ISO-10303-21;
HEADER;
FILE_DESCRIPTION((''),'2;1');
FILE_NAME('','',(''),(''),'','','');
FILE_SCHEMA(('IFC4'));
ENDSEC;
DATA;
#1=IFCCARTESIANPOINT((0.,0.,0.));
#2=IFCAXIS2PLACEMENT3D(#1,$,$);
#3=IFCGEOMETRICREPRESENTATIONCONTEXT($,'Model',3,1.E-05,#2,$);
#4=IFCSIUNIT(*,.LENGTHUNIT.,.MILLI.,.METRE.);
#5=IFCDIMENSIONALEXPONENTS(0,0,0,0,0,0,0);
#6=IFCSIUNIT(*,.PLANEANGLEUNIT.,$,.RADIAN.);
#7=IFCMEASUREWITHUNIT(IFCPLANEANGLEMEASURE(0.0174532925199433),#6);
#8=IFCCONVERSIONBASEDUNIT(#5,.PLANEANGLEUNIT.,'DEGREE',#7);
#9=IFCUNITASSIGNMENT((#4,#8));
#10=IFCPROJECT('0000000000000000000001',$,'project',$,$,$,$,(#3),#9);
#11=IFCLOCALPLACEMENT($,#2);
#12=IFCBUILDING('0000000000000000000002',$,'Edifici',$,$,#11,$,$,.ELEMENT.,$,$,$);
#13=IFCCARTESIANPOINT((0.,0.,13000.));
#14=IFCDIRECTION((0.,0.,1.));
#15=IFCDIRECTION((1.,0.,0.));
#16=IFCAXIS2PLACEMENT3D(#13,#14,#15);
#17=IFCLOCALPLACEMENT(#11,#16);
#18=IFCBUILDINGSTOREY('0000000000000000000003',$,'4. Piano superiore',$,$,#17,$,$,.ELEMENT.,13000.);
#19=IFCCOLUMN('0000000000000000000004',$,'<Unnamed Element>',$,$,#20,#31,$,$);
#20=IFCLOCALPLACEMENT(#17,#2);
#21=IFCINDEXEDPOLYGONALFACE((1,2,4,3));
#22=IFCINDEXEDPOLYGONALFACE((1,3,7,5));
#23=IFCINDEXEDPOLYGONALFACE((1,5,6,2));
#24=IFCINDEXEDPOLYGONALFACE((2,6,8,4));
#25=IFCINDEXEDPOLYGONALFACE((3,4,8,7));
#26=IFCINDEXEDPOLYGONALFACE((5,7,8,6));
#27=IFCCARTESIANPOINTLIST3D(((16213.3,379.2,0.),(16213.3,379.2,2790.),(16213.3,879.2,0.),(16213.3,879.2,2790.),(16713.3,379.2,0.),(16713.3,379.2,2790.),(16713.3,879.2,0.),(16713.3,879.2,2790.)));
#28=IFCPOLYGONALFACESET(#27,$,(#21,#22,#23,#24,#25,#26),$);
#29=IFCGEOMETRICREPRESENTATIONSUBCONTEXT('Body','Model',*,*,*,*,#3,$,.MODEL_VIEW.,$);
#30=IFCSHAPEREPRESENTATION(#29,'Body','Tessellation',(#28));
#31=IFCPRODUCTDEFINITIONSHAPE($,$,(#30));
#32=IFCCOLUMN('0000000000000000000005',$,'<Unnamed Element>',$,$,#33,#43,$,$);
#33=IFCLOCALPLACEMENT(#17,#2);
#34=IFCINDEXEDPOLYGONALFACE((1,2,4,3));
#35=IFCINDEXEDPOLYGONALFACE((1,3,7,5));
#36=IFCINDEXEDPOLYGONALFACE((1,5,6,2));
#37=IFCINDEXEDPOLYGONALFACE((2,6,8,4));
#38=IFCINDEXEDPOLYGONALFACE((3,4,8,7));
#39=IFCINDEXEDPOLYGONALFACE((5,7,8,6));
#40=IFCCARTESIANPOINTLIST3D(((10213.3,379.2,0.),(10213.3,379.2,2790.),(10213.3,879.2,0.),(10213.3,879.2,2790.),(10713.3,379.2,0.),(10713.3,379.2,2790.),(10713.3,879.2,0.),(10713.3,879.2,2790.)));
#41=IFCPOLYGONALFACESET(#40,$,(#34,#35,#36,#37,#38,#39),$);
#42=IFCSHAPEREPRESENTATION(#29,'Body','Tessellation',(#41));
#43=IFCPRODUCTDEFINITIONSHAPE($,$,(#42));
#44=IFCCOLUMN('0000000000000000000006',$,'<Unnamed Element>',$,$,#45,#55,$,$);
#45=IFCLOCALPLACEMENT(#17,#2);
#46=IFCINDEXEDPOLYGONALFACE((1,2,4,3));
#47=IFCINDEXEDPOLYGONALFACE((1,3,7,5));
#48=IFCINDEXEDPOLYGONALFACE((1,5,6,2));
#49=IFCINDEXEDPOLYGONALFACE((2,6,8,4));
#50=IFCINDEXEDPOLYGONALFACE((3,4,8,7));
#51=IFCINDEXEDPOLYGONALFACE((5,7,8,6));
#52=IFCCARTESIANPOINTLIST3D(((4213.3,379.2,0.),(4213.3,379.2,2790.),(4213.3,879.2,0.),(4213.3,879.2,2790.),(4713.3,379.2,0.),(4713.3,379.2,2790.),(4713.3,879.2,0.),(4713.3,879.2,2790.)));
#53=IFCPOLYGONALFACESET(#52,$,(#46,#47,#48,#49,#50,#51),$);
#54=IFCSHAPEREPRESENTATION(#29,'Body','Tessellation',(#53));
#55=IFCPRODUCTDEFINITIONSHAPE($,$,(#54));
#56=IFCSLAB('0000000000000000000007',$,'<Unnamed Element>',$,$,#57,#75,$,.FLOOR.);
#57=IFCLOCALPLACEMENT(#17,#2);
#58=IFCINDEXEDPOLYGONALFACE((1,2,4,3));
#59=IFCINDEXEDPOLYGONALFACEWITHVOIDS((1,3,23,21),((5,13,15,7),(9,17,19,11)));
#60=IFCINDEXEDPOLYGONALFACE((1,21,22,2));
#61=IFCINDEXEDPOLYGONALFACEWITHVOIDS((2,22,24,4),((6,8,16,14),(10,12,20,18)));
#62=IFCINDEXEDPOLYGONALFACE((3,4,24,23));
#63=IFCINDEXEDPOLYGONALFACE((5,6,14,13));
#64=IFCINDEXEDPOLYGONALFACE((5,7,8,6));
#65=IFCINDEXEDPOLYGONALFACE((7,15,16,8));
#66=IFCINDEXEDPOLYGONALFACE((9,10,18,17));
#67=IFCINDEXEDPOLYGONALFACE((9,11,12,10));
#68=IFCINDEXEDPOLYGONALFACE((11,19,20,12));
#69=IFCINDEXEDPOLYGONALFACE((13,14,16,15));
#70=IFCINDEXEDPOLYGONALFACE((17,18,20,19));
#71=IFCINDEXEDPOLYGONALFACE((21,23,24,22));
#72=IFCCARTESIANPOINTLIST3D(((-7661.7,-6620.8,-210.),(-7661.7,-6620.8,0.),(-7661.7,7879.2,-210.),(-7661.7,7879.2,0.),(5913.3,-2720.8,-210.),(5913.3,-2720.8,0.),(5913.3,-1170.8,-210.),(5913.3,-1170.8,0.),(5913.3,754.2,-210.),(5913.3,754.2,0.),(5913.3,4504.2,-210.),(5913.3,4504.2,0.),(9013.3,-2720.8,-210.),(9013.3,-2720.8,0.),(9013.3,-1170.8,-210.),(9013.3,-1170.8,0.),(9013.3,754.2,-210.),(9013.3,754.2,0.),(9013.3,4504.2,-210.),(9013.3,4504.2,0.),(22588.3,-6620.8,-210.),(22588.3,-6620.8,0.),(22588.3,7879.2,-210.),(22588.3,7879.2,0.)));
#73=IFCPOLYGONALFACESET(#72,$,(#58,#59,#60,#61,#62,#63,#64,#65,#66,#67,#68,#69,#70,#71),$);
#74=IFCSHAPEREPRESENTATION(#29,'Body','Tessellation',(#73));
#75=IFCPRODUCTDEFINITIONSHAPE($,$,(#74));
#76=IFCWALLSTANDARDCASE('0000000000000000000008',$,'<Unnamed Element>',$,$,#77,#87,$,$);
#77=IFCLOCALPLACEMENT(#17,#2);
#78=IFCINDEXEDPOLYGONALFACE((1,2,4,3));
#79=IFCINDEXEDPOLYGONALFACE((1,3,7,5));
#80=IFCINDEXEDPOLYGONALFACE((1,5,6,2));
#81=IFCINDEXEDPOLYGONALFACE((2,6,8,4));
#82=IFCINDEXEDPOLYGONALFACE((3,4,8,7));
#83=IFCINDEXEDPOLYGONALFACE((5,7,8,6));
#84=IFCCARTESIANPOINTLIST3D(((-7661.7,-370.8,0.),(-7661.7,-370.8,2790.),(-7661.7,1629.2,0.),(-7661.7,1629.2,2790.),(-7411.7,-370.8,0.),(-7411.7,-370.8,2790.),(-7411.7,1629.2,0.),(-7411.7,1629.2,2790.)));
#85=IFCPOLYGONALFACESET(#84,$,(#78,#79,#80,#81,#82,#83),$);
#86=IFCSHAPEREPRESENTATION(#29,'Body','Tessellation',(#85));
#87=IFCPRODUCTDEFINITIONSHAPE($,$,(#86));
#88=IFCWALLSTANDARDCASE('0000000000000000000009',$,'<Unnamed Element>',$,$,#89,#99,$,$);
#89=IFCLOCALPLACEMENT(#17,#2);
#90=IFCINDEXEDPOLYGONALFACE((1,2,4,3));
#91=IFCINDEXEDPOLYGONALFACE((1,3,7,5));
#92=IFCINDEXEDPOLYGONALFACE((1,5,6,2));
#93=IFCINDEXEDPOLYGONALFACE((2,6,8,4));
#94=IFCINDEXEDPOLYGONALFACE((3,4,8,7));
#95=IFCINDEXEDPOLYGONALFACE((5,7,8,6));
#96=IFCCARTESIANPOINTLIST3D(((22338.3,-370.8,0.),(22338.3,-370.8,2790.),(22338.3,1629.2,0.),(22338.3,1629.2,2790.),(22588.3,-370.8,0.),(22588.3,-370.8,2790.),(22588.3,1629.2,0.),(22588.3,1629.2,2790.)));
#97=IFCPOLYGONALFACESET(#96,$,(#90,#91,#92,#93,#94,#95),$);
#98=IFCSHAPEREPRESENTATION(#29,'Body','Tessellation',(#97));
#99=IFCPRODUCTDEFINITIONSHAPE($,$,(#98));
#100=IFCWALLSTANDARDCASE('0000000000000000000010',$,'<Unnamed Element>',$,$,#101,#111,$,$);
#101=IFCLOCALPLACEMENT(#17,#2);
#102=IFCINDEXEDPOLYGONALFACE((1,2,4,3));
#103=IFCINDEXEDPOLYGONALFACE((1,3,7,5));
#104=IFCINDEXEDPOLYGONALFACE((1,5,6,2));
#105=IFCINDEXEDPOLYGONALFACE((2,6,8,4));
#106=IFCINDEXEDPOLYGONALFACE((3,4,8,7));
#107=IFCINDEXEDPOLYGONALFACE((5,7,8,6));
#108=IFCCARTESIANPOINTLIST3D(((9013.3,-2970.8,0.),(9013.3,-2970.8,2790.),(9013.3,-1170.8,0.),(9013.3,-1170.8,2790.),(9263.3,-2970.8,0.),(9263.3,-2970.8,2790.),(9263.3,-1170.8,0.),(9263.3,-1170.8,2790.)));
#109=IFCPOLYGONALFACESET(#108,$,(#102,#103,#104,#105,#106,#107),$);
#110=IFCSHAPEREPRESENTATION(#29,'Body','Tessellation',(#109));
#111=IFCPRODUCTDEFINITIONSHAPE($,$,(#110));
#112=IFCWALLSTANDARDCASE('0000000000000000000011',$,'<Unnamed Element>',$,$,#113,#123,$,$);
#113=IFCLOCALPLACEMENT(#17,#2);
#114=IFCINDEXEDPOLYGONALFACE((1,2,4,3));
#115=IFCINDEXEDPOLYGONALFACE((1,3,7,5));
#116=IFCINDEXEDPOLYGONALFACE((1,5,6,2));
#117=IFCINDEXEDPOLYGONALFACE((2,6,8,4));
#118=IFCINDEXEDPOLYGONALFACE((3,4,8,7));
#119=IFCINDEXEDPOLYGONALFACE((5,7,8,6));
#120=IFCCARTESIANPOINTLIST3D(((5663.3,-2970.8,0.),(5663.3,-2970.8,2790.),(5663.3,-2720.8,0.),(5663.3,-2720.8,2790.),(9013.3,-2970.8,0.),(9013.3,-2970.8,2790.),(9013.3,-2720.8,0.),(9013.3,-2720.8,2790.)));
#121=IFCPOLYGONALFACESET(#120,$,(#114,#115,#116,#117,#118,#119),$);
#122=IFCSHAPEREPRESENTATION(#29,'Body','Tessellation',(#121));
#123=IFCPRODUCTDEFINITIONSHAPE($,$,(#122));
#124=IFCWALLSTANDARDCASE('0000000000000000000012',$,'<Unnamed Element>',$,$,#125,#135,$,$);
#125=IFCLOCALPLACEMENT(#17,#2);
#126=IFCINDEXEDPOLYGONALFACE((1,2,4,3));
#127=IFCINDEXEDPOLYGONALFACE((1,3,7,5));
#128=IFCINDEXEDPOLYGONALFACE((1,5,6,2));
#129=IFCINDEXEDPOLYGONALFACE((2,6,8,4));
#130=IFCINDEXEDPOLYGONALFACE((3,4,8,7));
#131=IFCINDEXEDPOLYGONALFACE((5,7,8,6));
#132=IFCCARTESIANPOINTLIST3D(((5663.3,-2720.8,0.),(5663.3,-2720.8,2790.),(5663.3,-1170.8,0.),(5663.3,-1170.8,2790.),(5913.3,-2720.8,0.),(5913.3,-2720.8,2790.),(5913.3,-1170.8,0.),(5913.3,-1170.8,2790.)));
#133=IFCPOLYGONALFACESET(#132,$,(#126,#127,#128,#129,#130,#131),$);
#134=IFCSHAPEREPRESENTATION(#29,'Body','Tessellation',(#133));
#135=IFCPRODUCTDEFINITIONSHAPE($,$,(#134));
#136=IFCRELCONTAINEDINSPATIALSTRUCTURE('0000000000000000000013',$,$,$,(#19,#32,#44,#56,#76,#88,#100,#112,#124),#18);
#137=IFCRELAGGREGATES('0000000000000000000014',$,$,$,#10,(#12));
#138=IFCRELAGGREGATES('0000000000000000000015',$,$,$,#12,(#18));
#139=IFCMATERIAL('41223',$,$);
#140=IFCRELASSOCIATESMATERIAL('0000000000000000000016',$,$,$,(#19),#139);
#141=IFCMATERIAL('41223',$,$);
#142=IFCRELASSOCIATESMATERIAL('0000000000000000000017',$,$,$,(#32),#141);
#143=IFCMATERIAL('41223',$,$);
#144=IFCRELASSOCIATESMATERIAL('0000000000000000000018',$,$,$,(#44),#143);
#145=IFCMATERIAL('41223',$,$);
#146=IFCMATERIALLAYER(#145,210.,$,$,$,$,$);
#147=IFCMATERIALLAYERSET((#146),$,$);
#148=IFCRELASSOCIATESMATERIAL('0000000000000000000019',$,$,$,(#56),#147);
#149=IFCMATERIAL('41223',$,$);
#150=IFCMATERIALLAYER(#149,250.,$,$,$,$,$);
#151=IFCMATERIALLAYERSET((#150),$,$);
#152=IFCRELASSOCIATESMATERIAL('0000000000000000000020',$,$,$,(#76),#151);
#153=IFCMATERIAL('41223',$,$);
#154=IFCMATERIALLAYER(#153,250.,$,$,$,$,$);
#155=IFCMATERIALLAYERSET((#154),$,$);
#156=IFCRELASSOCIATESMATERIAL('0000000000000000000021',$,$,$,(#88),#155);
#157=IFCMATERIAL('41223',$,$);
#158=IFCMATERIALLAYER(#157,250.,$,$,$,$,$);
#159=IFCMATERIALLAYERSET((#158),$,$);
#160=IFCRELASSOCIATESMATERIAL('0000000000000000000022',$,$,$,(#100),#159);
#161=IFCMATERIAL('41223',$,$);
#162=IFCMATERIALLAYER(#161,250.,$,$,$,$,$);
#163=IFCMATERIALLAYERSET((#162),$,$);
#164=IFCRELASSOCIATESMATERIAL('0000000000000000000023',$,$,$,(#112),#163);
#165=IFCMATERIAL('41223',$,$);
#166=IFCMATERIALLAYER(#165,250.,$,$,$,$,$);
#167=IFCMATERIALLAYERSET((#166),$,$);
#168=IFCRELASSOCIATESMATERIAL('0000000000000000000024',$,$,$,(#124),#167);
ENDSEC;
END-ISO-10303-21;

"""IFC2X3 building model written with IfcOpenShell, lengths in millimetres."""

from ifc_helpers import new_model, entity, si_unit, converted_unit, frame, frame_2d, origin, origin_with_axes, place, context, subcontext, project, spatial, polyline, rectangle, outline, extrude, material, layer, layer_set, layer_usage, element, save


model = new_model("IFC2X3")

# Units and contexts
model_context = context("Model", 3, precision=1e-05, world=origin())
body_context = subcontext(model_context, "Body", "Model", "MODEL_VIEW")
ifc_project = project(units=[si_unit("LENGTHUNIT", "METRE", prefix="MILLI"), converted_unit("PLANEANGLEUNIT", "DEGREE", entity("IfcPlaneAngleMeasure", 0.0174532925199433), si_unit("PLANEANGLEUNIT", "RADIAN"), dimensions=[0, 0, 0, 0, 0, 0, 0])], contexts=[model_context])

# Building, storey
building_placement = place(None, origin())
building = spatial("IfcBuilding", under=ifc_project, at=building_placement, Name="Edifici", CompositionType="ELEMENT")
storey_placement = place(building_placement, frame((0.0, 0.0, 13000.0), z_axis=(0.0, 0.0, 1.0), x_axis=(1.0, 0.0, 0.0)))
storey = spatial("IfcBuildingStorey", under=building, at=storey_placement, Name="4. Piano superiore", CompositionType="ELEMENT", Elevation=13000.0)

# Columns
ifc_material_1 = material(Name="41223")
column_1_placement = place(storey_placement, frame((16213.3, 379.2, 0.0), z_axis=(0.0, 0.0, 1.0), x_axis=(1.0, 0.0, 0.0)))
element("IfcColumn", 1, at=column_1_placement, inside=storey, material=ifc_material_1, Name="<Unnamed Element>", context=body_context, shape_type="SweptSolid", body=[
    extrude(rectangle(XDim=500.0, YDim=500.0, at=frame_2d((250.0, 250.0), x_axis=(1.0, 0.0))), origin_with_axes(), (0.0, 0.0, 1.0), 2790.0),
])
ifc_material_2 = material(Name="41223")
column_2_placement = place(storey_placement, frame((10213.3, 379.2, 0.0), z_axis=(0.0, 0.0, 1.0), x_axis=(1.0, 0.0, 0.0)))
element("IfcColumn", 2, at=column_2_placement, inside=storey, material=ifc_material_2, Name="<Unnamed Element>", context=body_context, shape_type="SweptSolid", body=[
    extrude(rectangle(XDim=500.0, YDim=500.0, at=frame_2d((250.0, 250.0), x_axis=(1.0, 0.0))), origin_with_axes(), (0.0, 0.0, 1.0), 2790.0),
])
ifc_material_3 = material(Name="41223")
column_3_placement = place(storey_placement, frame((4213.3, 379.2, 0.0), z_axis=(0.0, 0.0, 1.0), x_axis=(1.0, 0.0, 0.0)))
element("IfcColumn", 3, at=column_3_placement, inside=storey, material=ifc_material_3, Name="<Unnamed Element>", context=body_context, shape_type="SweptSolid", body=[
    extrude(rectangle(XDim=500.0, YDim=500.0, at=frame_2d((250.0, 250.0), x_axis=(1.0, 0.0))), origin_with_axes(), (0.0, 0.0, 1.0), 2790.0),
])

# Slab
ifc_material_4 = material(Name="41223")
ifc_layer_1 = layer(ifc_material_4, 210.0)
ifc_layer_set_1 = layer_set([ifc_layer_1])
ifc_layer_usage_1 = layer_usage(ifc_layer_set_1, "AXIS3", "POSITIVE", 0.0)
slab_placement = place(storey_placement, frame((-7661.7, -6620.8, -210.0), z_axis=(0.0, 0.0, 1.0), x_axis=(1.0, 0.0, 0.0)))
element("IfcSlab", 4, at=slab_placement, inside=storey, material=ifc_layer_usage_1, Name="<Unnamed Element>", PredefinedType="FLOOR", context=body_context, shape_type="SweptSolid", body=[
    extrude(outline(polyline([(0.0, 0.0), (30250.0, 0.0), (30250.0, 14500.0), (0.0, 14500.0), (0.0, 0.0)]), holes=[polyline([(13575.0, 11125.0), (16675.0, 11125.0), (16675.0, 7375.0), (13575.0, 7375.0), (13575.0, 11125.0)]), polyline([(16675.0, 3900.0), (13575.0, 3900.0), (13575.0, 5450.0), (16675.0, 5450.0), (16675.0, 3900.0)])]), origin_with_axes(), (0.0, 0.0, 1.0), 210.0),
])

# Walls
ifc_material_5 = material(Name="41223")
ifc_layer_2 = layer(ifc_material_5, 250.0)
ifc_layer_set_2 = layer_set([ifc_layer_2])
ifc_layer_usage_2 = layer_usage(ifc_layer_set_2, "AXIS2", "POSITIVE", 0.0)
wall_1_placement = place(storey_placement, frame((-7661.7, 1629.2, 0.0), z_axis=(0.0, 0.0, 1.0), x_axis=(0.0, -1.0, 0.0)))
element("IfcWallStandardCase", 5, at=wall_1_placement, inside=storey, material=ifc_layer_usage_2, Name="<Unnamed Element>", context=body_context, shape_type="SweptSolid", body=[
    extrude(rectangle(XDim=2000.0, YDim=250.0, at=frame_2d((1000.0, 125.0), x_axis=(1.0, 0.0))), origin_with_axes(), (0.0, 0.0, 1.0), 2790.0),
])
ifc_material_6 = material(Name="41223")
ifc_layer_3 = layer(ifc_material_6, 250.0)
ifc_layer_set_3 = layer_set([ifc_layer_3])
ifc_layer_usage_3 = layer_usage(ifc_layer_set_3, "AXIS2", "POSITIVE", 0.0)
wall_2_placement = place(storey_placement, frame((22338.3, 1629.2, 0.0), z_axis=(0.0, 0.0, 1.0), x_axis=(0.0, -1.0, 0.0)))
element("IfcWallStandardCase", 6, at=wall_2_placement, inside=storey, material=ifc_layer_usage_3, Name="<Unnamed Element>", context=body_context, shape_type="SweptSolid", body=[
    extrude(rectangle(XDim=2000.0, YDim=250.0, at=frame_2d((1000.0, 125.0), x_axis=(1.0, 0.0))), origin_with_axes(), (0.0, 0.0, 1.0), 2790.0),
])
ifc_material_7 = material(Name="41223")
ifc_layer_4 = layer(ifc_material_7, 250.0)
ifc_layer_set_4 = layer_set([ifc_layer_4])
ifc_layer_usage_4 = layer_usage(ifc_layer_set_4, "AXIS2", "POSITIVE", 0.0)
wall_3_placement = place(storey_placement, frame((9263.3, -2970.8, 0.0), z_axis=(0.0, 0.0, 1.0), x_axis=(0.0, 1.0, 0.0)))
element("IfcWallStandardCase", 7, at=wall_3_placement, inside=storey, material=ifc_layer_usage_4, Name="<Unnamed Element>", context=body_context, shape_type="SweptSolid", body=[
    extrude(rectangle(XDim=1800.0, YDim=250.0, at=frame_2d((900.0, 125.0), x_axis=(1.0, 0.0))), origin_with_axes(), (0.0, 0.0, 1.0), 2790.0),
])
ifc_material_8 = material(Name="41223")
ifc_layer_5 = layer(ifc_material_8, 250.0)
ifc_layer_set_5 = layer_set([ifc_layer_5])
ifc_layer_usage_5 = layer_usage(ifc_layer_set_5, "AXIS2", "POSITIVE", 0.0)
wall_4_placement = place(storey_placement, frame((5663.3, -2970.8, 0.0), z_axis=(0.0, 0.0, 1.0), x_axis=(1.0, 0.0, 0.0)))
element("IfcWallStandardCase", 8, at=wall_4_placement, inside=storey, material=ifc_layer_usage_5, Name="<Unnamed Element>", context=body_context, shape_type="SweptSolid", body=[
    extrude(rectangle(XDim=3350.0, YDim=250.0, at=frame_2d((1675.0, 125.0), x_axis=(1.0, 0.0))), origin_with_axes(), (0.0, 0.0, 1.0), 2790.0),
])
ifc_material_9 = material(Name="41223")
ifc_layer_6 = layer(ifc_material_9, 250.0)
ifc_layer_set_6 = layer_set([ifc_layer_6])
ifc_layer_usage_6 = layer_usage(ifc_layer_set_6, "AXIS2", "POSITIVE", 0.0)
wall_5_placement = place(storey_placement, frame((5663.3, -1170.8, 0.0), z_axis=(0.0, 0.0, 1.0), x_axis=(0.0, -1.0, 0.0)))
element("IfcWallStandardCase", 9, at=wall_5_placement, inside=storey, material=ifc_layer_usage_6, Name="<Unnamed Element>", context=body_context, shape_type="SweptSolid", body=[
    extrude(rectangle(XDim=1550.0, YDim=250.0, at=frame_2d((775.0, 125.0), x_axis=(1.0, 0.0))), origin_with_axes(), (0.0, 0.0, 1.0), 2790.0),
])

save(model, "model.ifc")
